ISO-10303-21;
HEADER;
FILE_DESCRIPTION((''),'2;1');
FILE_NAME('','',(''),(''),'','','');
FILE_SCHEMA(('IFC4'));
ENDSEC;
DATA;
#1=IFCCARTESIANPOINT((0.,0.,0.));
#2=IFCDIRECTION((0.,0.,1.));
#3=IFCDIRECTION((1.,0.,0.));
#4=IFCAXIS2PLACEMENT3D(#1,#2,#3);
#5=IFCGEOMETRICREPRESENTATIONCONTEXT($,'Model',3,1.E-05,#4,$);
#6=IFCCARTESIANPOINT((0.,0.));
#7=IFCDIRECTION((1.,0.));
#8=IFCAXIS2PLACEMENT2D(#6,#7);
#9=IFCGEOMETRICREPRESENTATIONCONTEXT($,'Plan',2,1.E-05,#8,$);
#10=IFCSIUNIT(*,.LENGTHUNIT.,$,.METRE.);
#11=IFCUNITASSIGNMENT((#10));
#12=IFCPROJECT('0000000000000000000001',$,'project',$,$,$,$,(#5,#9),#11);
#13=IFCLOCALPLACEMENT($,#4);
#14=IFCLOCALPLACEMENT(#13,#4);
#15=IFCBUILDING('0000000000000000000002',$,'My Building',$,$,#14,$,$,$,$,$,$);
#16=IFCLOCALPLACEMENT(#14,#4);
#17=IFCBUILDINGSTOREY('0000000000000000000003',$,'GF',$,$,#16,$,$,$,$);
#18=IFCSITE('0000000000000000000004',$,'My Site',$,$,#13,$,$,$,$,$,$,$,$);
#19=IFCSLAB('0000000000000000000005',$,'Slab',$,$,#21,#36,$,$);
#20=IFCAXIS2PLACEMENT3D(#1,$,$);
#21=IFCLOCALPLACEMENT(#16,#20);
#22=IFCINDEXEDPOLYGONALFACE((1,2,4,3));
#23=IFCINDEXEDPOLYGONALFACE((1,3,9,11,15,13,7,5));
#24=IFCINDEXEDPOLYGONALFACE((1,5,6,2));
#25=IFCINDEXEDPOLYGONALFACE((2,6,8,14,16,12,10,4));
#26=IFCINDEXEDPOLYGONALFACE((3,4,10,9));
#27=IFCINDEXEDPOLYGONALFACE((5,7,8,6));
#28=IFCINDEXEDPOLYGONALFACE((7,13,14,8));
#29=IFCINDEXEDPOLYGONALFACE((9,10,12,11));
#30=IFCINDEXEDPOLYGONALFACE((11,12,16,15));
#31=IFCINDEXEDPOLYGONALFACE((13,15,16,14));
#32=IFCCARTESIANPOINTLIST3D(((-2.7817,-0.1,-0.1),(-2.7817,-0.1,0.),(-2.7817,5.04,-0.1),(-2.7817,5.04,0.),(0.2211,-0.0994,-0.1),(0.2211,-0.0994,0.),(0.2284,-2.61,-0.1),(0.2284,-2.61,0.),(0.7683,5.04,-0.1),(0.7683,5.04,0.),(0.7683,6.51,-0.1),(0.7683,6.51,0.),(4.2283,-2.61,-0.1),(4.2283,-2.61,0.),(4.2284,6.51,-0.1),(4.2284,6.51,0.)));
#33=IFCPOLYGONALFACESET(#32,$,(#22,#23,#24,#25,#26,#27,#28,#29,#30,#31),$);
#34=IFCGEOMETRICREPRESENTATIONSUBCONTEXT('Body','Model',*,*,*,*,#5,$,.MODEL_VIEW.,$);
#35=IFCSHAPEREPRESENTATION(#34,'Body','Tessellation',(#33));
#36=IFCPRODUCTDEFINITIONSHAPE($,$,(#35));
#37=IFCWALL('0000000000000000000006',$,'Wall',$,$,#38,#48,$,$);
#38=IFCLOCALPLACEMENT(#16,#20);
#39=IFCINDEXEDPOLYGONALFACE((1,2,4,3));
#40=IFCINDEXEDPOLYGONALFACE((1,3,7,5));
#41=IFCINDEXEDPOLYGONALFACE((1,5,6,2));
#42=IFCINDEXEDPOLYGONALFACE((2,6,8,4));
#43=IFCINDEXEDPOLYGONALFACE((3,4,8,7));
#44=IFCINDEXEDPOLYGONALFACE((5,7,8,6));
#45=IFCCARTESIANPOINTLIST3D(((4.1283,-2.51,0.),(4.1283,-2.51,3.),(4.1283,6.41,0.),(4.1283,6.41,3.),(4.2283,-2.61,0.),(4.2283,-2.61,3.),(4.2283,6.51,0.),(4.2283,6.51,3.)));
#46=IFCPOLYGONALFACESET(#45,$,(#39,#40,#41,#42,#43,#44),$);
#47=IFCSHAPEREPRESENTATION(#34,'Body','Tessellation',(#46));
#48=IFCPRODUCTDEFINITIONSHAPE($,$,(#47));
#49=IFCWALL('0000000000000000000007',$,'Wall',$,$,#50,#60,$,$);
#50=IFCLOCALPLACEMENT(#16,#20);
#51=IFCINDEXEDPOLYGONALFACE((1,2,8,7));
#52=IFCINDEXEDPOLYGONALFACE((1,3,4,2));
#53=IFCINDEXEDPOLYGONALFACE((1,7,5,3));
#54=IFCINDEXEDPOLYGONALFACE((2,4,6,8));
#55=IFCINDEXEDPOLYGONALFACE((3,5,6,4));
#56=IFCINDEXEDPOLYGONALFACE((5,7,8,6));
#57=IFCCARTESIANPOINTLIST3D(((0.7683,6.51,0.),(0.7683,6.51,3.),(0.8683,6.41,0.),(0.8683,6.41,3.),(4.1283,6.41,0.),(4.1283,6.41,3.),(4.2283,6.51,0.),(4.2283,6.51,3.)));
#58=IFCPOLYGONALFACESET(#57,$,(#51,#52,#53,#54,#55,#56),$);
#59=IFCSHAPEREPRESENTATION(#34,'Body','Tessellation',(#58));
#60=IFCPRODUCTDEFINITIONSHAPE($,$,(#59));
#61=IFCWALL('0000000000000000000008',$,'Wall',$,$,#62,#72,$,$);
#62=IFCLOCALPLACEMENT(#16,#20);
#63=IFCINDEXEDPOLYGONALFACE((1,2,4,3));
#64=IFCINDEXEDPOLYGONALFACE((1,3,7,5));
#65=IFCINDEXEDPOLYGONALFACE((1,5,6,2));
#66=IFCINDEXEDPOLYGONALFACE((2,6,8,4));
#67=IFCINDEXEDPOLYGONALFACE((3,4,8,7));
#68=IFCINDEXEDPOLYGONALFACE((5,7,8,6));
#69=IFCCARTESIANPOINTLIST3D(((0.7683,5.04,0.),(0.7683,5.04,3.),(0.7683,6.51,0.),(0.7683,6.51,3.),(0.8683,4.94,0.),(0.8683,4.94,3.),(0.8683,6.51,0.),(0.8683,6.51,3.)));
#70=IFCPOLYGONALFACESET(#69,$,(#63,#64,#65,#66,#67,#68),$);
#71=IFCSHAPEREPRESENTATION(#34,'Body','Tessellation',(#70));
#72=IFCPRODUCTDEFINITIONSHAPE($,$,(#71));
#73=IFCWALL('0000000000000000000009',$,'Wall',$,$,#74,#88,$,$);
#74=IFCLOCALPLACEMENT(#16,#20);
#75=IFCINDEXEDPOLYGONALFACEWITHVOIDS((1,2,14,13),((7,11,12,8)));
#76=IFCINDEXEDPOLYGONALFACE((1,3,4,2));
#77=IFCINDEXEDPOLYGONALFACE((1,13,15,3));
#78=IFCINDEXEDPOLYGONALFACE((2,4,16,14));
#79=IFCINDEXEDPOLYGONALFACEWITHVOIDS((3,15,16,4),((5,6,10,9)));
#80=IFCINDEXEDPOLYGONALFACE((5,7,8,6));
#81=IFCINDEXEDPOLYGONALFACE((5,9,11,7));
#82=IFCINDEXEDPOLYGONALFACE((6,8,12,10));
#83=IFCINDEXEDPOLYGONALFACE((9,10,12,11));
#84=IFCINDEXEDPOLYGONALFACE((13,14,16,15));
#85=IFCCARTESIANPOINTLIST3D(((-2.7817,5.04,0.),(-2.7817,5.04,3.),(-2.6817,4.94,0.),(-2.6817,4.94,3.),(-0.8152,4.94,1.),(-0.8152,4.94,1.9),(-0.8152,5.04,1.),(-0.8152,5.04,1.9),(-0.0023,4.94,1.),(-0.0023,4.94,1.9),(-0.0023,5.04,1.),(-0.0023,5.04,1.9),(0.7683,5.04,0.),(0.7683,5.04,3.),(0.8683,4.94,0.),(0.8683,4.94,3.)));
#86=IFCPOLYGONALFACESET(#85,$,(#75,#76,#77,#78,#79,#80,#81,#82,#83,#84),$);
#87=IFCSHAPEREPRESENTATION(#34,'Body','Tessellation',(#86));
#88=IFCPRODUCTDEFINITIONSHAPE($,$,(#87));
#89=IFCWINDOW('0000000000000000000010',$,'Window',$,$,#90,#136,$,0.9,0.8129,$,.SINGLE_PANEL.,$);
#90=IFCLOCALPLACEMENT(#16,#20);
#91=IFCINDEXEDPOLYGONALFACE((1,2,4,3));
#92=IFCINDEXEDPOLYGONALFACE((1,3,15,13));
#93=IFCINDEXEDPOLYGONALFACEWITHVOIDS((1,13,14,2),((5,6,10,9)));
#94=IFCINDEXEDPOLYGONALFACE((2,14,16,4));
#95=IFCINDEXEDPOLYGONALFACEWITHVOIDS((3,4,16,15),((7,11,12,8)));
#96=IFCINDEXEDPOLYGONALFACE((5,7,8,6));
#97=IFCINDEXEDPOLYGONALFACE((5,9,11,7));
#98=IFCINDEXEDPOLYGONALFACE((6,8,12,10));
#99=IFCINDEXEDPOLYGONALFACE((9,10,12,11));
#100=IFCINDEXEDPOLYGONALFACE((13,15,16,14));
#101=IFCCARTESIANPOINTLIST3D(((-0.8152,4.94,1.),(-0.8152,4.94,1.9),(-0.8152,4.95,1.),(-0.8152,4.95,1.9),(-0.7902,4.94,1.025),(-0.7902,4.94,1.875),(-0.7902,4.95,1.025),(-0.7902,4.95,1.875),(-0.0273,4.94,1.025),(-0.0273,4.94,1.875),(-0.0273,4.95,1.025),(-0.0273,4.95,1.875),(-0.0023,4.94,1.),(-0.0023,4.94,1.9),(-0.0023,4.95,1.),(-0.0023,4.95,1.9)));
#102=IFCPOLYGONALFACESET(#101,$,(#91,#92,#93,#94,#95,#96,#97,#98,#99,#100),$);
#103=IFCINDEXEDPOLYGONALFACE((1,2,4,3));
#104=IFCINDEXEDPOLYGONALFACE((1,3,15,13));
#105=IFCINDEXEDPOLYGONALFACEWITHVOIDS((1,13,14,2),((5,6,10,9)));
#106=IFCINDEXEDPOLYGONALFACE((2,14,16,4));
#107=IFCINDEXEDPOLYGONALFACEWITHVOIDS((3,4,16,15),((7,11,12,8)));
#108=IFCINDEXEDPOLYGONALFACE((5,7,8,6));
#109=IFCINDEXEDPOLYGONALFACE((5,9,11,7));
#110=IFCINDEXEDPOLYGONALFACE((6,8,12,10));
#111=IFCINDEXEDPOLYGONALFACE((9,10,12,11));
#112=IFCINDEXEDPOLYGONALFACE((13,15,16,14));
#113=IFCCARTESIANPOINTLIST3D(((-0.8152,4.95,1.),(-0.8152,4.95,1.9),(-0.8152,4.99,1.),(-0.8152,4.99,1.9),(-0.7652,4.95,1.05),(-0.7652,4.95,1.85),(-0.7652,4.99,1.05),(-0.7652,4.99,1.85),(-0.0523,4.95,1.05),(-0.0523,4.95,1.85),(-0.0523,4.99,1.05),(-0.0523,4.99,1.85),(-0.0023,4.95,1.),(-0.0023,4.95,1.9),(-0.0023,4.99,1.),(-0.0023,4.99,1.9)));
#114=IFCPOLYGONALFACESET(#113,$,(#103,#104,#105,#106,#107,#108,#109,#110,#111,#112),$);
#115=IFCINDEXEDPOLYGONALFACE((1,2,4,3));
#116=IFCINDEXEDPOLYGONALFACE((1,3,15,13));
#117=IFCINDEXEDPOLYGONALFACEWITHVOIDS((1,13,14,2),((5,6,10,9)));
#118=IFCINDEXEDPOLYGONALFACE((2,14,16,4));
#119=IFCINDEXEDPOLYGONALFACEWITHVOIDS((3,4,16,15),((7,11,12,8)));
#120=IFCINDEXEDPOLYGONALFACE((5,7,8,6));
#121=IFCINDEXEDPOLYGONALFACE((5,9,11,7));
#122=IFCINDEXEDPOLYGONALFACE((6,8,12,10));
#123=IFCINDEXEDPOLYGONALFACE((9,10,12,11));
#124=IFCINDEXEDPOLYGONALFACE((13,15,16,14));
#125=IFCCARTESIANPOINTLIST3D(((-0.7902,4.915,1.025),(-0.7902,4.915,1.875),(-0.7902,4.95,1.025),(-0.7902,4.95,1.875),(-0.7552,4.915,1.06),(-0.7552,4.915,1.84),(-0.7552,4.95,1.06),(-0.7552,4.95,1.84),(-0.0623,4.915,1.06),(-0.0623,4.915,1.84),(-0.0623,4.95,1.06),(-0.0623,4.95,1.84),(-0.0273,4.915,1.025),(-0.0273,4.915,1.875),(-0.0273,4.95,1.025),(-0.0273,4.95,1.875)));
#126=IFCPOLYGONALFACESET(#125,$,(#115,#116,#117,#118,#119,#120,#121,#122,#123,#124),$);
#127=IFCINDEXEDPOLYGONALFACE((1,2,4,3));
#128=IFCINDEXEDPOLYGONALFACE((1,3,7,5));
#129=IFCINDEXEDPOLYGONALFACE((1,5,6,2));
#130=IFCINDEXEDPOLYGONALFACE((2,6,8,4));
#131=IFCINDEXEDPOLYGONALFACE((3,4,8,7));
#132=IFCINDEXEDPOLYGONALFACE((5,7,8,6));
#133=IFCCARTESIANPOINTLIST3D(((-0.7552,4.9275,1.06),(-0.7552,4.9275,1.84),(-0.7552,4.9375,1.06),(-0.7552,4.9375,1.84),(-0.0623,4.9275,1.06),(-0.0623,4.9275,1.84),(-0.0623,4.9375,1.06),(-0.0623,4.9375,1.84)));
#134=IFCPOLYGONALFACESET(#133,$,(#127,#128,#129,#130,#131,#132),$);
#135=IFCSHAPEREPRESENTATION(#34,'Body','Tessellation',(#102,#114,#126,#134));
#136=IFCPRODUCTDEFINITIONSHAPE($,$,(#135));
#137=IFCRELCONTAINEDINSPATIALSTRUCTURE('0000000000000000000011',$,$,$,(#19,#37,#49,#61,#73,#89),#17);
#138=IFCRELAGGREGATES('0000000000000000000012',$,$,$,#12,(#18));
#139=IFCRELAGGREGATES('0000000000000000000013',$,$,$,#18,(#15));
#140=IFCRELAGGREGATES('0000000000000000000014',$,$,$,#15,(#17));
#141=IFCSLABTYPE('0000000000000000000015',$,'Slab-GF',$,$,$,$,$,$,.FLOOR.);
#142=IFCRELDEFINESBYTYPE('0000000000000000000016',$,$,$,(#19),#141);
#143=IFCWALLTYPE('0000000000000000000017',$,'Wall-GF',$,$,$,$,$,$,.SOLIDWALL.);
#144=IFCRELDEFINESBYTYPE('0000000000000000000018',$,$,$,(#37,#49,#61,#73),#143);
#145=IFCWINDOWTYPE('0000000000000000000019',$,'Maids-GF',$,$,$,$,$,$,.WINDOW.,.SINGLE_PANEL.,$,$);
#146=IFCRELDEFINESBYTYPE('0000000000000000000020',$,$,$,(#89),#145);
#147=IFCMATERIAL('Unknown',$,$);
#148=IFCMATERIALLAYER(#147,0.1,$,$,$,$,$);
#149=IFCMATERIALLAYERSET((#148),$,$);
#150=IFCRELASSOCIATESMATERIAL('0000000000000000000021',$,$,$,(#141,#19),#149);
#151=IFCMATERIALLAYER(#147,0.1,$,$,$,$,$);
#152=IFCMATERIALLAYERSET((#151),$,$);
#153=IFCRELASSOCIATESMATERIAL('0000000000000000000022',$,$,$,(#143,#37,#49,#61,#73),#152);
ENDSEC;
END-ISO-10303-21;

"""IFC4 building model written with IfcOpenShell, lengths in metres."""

from ifc_helpers import new_model, entity, si_unit, frame, origin_with_axes, origin_2d_with_axis, place, context, subcontext, project, spatial, line, indexed_curve, outline, extrude, shape, source, transform, mapped, material, layer, layer_set, layer_usage, type_object, type_shapes, element, fill, save


model = new_model("IFC4")

# Units and contexts
model_context = context("Model", 3, precision=1e-05, world=origin_with_axes())
plan_context = context("Plan", 2, precision=1e-05, world=origin_2d_with_axis())
body_context_1 = subcontext(model_context, "Body", "Model", "MODEL_VIEW")
body_context_2 = subcontext(plan_context, "Body", "Plan", "PLAN_VIEW")
ifc_project = project(units=[si_unit("LENGTHUNIT", "METRE")], contexts=[model_context, plan_context])

# Site, building, storey
site_placement = place(None, origin_with_axes())
site = spatial("IfcSite", under=ifc_project, at=site_placement, Name="My Site")
building_placement = place(site_placement, origin_with_axes())
building = spatial("IfcBuilding", under=site, at=building_placement, Name="My Building")
storey_placement = place(building_placement, origin_with_axes())
storey = spatial("IfcBuildingStorey", under=building, at=storey_placement, Name="GF")

# Slab
ifc_material = material(Name="Unknown")
ifc_layer_1 = layer(ifc_material, 0.1)
ifc_layer_set_1 = layer_set([ifc_layer_1])
ifc_layer_usage_1 = layer_usage(ifc_layer_set_1, "AXIS3", "POSITIVE", -0.1)
slab_type = type_object("IfcSlabType", Name="Slab-GF", PredefinedType="FLOOR", material=ifc_layer_set_1)
slab_placement = place(storey_placement, frame((4.2283, -2.61, 0.0), z_axis=(0.0, 0.0, 1.0), x_axis=(1.0, 0.0, 0.0)))
element("IfcSlab", 1, at=slab_placement, inside=storey, type_object=slab_type, material=ifc_layer_usage_1, Name="Slab", context=body_context_1, shape_type="SweptSolid", body=[
    extrude(outline(indexed_curve([(0.0, 0.0), (0.0, 9.12), (-3.46, 9.12), (-3.46, 7.65), (-7.01, 7.65), (-7.01, 2.51), (-4.0073, 2.5106), (-4.0, 0.0), (0.0, 0.0)])), frame((0.0, 0.0, -0.1), z_axis=(0.0, 0.0, 1.0), x_axis=(1.0, 0.0, 0.0)), (0.0, 0.0, 1.0), 0.1),
])

# Shared definitions
ifc_layer_2 = layer(ifc_material, 0.1)
ifc_layer_set_2 = layer_set([ifc_layer_2])
wall_type = type_object("IfcWallType", Name="Wall-GF", PredefinedType="SOLIDWALL", material=ifc_layer_set_2)

# Walls
ifc_layer_usage_2 = layer_usage(ifc_layer_set_2, "AXIS2", "POSITIVE", 0.0)
wall_1_placement = place(storey_placement, frame((4.2283, -2.61, 0.0), z_axis=(0.0, 0.0, 1.0), x_axis=(0.0, 1.0, 0.0)))
element("IfcWall", 2, at=wall_1_placement, inside=storey, type_object=wall_type, material=ifc_layer_usage_2, Name="Wall", context=body_context_1, shape_type="SweptSolid", body=[
    extrude(outline(indexed_curve([(0.0, 0.0), (0.1, 0.1), (9.02, 0.1), (9.12, 0.0)], segments=[line(1, 2, 3, 4, 1)])), origin_with_axes(), (0.0, 0.0, 1.0), 3.0),
])
ifc_layer_usage_3 = layer_usage(ifc_layer_set_2, "AXIS2", "POSITIVE", 0.0)
wall_2_placement = place(storey_placement, frame((4.2283, 6.51, 0.0), z_axis=(0.0, 0.0, 1.0), x_axis=(-1.0, 0.0, 0.0)))
element("IfcWall", 3, at=wall_2_placement, inside=storey, type_object=wall_type, material=ifc_layer_usage_3, Name="Wall", context=body_context_1, shape_type="SweptSolid", body=[
    extrude(outline(indexed_curve([(0.0, 0.0), (0.1, 0.1), (3.36, 0.1), (3.46, 0.0)], segments=[line(1, 2, 3, 4, 1)])), origin_with_axes(), (0.0, 0.0, 1.0), 3.0),
])
ifc_layer_usage_4 = layer_usage(ifc_layer_set_2, "AXIS2", "POSITIVE", 0.0)
wall_3_placement = place(storey_placement, frame((0.7683, 6.51, 0.0), z_axis=(0.0, 0.0, 1.0), x_axis=(0.0, -1.0, 0.0)))
element("IfcWall", 4, at=wall_3_placement, inside=storey, type_object=wall_type, material=ifc_layer_usage_4, Name="Wall", context=body_context_1, shape_type="SweptSolid", body=[
    extrude(outline(indexed_curve([(0.0, 0.0), (0.0, 0.1), (1.57, 0.1), (1.47, 0.0)], segments=[line(1, 2, 3, 4, 1)])), origin_with_axes(), (0.0, 0.0, 1.0), 3.0),
])

# Wall, opening, window
ifc_layer_usage_5 = layer_usage(ifc_layer_set_2, "AXIS2", "POSITIVE", 0.0)
wall_4_placement = place(storey_placement, frame((0.7683, 5.04, 0.0), z_axis=(0.0, 0.0, 1.0), x_axis=(-1.0, 0.0, 0.0)))
wall_4 = element("IfcWall", 5, at=wall_4_placement, inside=storey, type_object=wall_type, material=ifc_layer_usage_5, Name="Wall", context=body_context_1, shape_type="SweptSolid", body=[
    extrude(outline(indexed_curve([(0.0, 0.0), (-0.1, 0.1), (3.45, 0.1), (3.55, 0.0)], segments=[line(1, 2, 3, 4, 1)])), origin_with_axes(), (0.0, 0.0, 1.0), 3.0),
])
shared_shape_1 = source(origin_with_axes(), body_context_1, "Body", "SweptSolid", [
    extrude(outline(indexed_curve([(0.0, 0.0), (0.8129, 0.0), (0.8129, 0.9), (0.0, 0.9)], segments=[line(1, 2, 3, 4, 1)])), frame((0.0, -0.6, 0.0), z_axis=(0.0, -1.0, 0.0), x_axis=(1.0, 0.0, 0.0)), (0.0, 0.0, -1.0), 1.2),
])
opening_1_placement = place(wall_4_placement, frame((0.7707, 0.0, 1.0), z_axis=(0.0, 0.0, 1.0), x_axis=(1.0, 0.0, 0.0)))
opening_1 = element("IfcOpeningElement", 6, at=opening_1_placement, cuts=wall_4, PredefinedType="OPENING", context=body_context_1, shape_type="MappedRepresentation", body=[
    mapped(shared_shape_1, transform((0.0, 0.0, 0.0), x_axis=(1.0, 0.0, 0.0), y_axis=(0.0, 1.0, 0.0), z_axis=(0.0, 0.0, 1.0), scale=1.0)),
])
window_type_1 = type_object("IfcWindowType", Name="Maids-GF", PartitioningType="SINGLE_PANEL", PredefinedType="WINDOW")
shared_shape_2 = source(origin_with_axes(), body_context_1, "Body", "SweptSolid", [
    extrude(outline(indexed_curve([(0.0, 0.0), (0.8129, 0.0), (0.8129, 0.9), (0.0, 0.9)], segments=[line(1, 2, 3, 4, 1)]), holes=[indexed_curve([(0.025, 0.025), (0.7879, 0.025), (0.7879, 0.875), (0.025, 0.875)], segments=[line(1, 2, 3, 4, 1)])]), frame((0.0, 0.09, 0.0), z_axis=(0.0, -1.0, 0.0), x_axis=(1.0, 0.0, 0.0)), (0.0, 0.0, -1.0), 0.01),
    extrude(outline(indexed_curve([(0.0, 0.0), (0.8129, 0.0), (0.8129, 0.9), (0.0, 0.9)], segments=[line(1, 2, 3, 4, 1)]), holes=[indexed_curve([(0.05, 0.05), (0.7629, 0.05), (0.7629, 0.85), (0.05, 0.85)], segments=[line(1, 2, 3, 4, 1)])]), frame((0.0, 0.05, 0.0), z_axis=(0.0, -1.0, 0.0), x_axis=(1.0, 0.0, 0.0)), (0.0, 0.0, -1.0), 0.04),
    extrude(outline(indexed_curve([(0.0, 0.0), (0.7629, 0.0), (0.7629, 0.85), (0.0, 0.85)], segments=[line(1, 2, 3, 4, 1)]), holes=[indexed_curve([(0.035, 0.035), (0.7279, 0.035), (0.7279, 0.815), (0.035, 0.815)], segments=[line(1, 2, 3, 4, 1)])]), frame((0.025, 0.09, 0.025), z_axis=(0.0, -1.0, 0.0), x_axis=(1.0, 0.0, 0.0)), (0.0, 0.0, -1.0), 0.035),
    extrude(outline(indexed_curve([(0.035, 0.035), (0.7279, 0.035), (0.7279, 0.815), (0.035, 0.815)], segments=[line(1, 2, 3, 4, 1)])), frame((0.025, 0.1025, 0.025), z_axis=(0.0, -1.0, 0.0), x_axis=(1.0, 0.0, 0.0)), (0.0, 0.0, -1.0), 0.01),
])
shared_shape_3 = source(origin_with_axes(), body_context_2, "Body", "Curve2D", [
    entity("IfcIndexedPolyCurve", entity("IfcCartesianPointList2D", [[0.05, 0.05], [0.7629, 0.05]])),
    entity("IfcIndexedPolyCurve", entity("IfcCartesianPointList2D", [[0.0, 0.1], [0.025, 0.1], [0.025, 0.09], [0.05, 0.09], [0.05, 0.05], [0.0, 0.05]]), [entity("IfcLineIndex", [1, 2, 3, 4, 5, 6, 1])]),
    entity("IfcIndexedPolyCurve", entity("IfcCartesianPointList2D", [[0.8129, 0.1], [0.7879, 0.1], [0.7879, 0.09], [0.7629, 0.09], [0.7629, 0.05], [0.8129, 0.05]]), [entity("IfcLineIndex", [1, 2, 3, 4, 5, 6, 1])]),
    entity("IfcIndexedPolyCurve", entity("IfcCartesianPointList2D", [[0.025, 0.09], [0.06, 0.09], [0.06, 0.125], [0.025, 0.125]]), [entity("IfcLineIndex", [1, 2, 3, 4, 1])]),
    entity("IfcIndexedPolyCurve", entity("IfcCartesianPointList2D", [[0.7879, 0.09], [0.7529, 0.09], [0.7529, 0.125], [0.7879, 0.125]]), [entity("IfcLineIndex", [1, 2, 3, 4, 1])]),
    entity("IfcIndexedPolyCurve", entity("IfcCartesianPointList2D", [[0.06, 0.09], [0.7529, 0.09]])),
    entity("IfcIndexedPolyCurve", entity("IfcCartesianPointList2D", [[0.06, 0.125], [0.7529, 0.125]])),
    entity("IfcIndexedPolyCurve", entity("IfcCartesianPointList2D", [[0.06, 0.1075], [0.7529, 0.1075]])),
])
type_shapes(window_type_1, [shared_shape_2, shared_shape_3])
window_1_placement = place(opening_1_placement, frame((0.0, 0.0, 0.0), z_axis=(0.0, 0.0, 1.0), x_axis=(1.0, 0.0, 0.0)))
window_1 = element("IfcWindow", 7, at=window_1_placement, inside=storey, type_object=window_type_1, Name="Window", OverallHeight=0.9, OverallWidth=0.8129, PartitioningType="SINGLE_PANEL", shapes=[
    shape(body_context_1, "Body", "MappedRepresentation", [mapped(shared_shape_2, transform((0.0, 0.0, 0.0), x_axis=(1.0, 0.0, 0.0), y_axis=(0.0, 1.0, 0.0), z_axis=(0.0, 0.0, 1.0), scale=1.0))]),
    shape(body_context_2, "Body", "MappedRepresentation", [mapped(shared_shape_3, transform((0.0, 0.0, 0.0), x_axis=(1.0, 0.0, 0.0), y_axis=(0.0, 1.0, 0.0), z_axis=(0.0, 0.0, 1.0), scale=1.0))]),
])
fill(opening_1, window_1)

save(model, "model.ifc")
